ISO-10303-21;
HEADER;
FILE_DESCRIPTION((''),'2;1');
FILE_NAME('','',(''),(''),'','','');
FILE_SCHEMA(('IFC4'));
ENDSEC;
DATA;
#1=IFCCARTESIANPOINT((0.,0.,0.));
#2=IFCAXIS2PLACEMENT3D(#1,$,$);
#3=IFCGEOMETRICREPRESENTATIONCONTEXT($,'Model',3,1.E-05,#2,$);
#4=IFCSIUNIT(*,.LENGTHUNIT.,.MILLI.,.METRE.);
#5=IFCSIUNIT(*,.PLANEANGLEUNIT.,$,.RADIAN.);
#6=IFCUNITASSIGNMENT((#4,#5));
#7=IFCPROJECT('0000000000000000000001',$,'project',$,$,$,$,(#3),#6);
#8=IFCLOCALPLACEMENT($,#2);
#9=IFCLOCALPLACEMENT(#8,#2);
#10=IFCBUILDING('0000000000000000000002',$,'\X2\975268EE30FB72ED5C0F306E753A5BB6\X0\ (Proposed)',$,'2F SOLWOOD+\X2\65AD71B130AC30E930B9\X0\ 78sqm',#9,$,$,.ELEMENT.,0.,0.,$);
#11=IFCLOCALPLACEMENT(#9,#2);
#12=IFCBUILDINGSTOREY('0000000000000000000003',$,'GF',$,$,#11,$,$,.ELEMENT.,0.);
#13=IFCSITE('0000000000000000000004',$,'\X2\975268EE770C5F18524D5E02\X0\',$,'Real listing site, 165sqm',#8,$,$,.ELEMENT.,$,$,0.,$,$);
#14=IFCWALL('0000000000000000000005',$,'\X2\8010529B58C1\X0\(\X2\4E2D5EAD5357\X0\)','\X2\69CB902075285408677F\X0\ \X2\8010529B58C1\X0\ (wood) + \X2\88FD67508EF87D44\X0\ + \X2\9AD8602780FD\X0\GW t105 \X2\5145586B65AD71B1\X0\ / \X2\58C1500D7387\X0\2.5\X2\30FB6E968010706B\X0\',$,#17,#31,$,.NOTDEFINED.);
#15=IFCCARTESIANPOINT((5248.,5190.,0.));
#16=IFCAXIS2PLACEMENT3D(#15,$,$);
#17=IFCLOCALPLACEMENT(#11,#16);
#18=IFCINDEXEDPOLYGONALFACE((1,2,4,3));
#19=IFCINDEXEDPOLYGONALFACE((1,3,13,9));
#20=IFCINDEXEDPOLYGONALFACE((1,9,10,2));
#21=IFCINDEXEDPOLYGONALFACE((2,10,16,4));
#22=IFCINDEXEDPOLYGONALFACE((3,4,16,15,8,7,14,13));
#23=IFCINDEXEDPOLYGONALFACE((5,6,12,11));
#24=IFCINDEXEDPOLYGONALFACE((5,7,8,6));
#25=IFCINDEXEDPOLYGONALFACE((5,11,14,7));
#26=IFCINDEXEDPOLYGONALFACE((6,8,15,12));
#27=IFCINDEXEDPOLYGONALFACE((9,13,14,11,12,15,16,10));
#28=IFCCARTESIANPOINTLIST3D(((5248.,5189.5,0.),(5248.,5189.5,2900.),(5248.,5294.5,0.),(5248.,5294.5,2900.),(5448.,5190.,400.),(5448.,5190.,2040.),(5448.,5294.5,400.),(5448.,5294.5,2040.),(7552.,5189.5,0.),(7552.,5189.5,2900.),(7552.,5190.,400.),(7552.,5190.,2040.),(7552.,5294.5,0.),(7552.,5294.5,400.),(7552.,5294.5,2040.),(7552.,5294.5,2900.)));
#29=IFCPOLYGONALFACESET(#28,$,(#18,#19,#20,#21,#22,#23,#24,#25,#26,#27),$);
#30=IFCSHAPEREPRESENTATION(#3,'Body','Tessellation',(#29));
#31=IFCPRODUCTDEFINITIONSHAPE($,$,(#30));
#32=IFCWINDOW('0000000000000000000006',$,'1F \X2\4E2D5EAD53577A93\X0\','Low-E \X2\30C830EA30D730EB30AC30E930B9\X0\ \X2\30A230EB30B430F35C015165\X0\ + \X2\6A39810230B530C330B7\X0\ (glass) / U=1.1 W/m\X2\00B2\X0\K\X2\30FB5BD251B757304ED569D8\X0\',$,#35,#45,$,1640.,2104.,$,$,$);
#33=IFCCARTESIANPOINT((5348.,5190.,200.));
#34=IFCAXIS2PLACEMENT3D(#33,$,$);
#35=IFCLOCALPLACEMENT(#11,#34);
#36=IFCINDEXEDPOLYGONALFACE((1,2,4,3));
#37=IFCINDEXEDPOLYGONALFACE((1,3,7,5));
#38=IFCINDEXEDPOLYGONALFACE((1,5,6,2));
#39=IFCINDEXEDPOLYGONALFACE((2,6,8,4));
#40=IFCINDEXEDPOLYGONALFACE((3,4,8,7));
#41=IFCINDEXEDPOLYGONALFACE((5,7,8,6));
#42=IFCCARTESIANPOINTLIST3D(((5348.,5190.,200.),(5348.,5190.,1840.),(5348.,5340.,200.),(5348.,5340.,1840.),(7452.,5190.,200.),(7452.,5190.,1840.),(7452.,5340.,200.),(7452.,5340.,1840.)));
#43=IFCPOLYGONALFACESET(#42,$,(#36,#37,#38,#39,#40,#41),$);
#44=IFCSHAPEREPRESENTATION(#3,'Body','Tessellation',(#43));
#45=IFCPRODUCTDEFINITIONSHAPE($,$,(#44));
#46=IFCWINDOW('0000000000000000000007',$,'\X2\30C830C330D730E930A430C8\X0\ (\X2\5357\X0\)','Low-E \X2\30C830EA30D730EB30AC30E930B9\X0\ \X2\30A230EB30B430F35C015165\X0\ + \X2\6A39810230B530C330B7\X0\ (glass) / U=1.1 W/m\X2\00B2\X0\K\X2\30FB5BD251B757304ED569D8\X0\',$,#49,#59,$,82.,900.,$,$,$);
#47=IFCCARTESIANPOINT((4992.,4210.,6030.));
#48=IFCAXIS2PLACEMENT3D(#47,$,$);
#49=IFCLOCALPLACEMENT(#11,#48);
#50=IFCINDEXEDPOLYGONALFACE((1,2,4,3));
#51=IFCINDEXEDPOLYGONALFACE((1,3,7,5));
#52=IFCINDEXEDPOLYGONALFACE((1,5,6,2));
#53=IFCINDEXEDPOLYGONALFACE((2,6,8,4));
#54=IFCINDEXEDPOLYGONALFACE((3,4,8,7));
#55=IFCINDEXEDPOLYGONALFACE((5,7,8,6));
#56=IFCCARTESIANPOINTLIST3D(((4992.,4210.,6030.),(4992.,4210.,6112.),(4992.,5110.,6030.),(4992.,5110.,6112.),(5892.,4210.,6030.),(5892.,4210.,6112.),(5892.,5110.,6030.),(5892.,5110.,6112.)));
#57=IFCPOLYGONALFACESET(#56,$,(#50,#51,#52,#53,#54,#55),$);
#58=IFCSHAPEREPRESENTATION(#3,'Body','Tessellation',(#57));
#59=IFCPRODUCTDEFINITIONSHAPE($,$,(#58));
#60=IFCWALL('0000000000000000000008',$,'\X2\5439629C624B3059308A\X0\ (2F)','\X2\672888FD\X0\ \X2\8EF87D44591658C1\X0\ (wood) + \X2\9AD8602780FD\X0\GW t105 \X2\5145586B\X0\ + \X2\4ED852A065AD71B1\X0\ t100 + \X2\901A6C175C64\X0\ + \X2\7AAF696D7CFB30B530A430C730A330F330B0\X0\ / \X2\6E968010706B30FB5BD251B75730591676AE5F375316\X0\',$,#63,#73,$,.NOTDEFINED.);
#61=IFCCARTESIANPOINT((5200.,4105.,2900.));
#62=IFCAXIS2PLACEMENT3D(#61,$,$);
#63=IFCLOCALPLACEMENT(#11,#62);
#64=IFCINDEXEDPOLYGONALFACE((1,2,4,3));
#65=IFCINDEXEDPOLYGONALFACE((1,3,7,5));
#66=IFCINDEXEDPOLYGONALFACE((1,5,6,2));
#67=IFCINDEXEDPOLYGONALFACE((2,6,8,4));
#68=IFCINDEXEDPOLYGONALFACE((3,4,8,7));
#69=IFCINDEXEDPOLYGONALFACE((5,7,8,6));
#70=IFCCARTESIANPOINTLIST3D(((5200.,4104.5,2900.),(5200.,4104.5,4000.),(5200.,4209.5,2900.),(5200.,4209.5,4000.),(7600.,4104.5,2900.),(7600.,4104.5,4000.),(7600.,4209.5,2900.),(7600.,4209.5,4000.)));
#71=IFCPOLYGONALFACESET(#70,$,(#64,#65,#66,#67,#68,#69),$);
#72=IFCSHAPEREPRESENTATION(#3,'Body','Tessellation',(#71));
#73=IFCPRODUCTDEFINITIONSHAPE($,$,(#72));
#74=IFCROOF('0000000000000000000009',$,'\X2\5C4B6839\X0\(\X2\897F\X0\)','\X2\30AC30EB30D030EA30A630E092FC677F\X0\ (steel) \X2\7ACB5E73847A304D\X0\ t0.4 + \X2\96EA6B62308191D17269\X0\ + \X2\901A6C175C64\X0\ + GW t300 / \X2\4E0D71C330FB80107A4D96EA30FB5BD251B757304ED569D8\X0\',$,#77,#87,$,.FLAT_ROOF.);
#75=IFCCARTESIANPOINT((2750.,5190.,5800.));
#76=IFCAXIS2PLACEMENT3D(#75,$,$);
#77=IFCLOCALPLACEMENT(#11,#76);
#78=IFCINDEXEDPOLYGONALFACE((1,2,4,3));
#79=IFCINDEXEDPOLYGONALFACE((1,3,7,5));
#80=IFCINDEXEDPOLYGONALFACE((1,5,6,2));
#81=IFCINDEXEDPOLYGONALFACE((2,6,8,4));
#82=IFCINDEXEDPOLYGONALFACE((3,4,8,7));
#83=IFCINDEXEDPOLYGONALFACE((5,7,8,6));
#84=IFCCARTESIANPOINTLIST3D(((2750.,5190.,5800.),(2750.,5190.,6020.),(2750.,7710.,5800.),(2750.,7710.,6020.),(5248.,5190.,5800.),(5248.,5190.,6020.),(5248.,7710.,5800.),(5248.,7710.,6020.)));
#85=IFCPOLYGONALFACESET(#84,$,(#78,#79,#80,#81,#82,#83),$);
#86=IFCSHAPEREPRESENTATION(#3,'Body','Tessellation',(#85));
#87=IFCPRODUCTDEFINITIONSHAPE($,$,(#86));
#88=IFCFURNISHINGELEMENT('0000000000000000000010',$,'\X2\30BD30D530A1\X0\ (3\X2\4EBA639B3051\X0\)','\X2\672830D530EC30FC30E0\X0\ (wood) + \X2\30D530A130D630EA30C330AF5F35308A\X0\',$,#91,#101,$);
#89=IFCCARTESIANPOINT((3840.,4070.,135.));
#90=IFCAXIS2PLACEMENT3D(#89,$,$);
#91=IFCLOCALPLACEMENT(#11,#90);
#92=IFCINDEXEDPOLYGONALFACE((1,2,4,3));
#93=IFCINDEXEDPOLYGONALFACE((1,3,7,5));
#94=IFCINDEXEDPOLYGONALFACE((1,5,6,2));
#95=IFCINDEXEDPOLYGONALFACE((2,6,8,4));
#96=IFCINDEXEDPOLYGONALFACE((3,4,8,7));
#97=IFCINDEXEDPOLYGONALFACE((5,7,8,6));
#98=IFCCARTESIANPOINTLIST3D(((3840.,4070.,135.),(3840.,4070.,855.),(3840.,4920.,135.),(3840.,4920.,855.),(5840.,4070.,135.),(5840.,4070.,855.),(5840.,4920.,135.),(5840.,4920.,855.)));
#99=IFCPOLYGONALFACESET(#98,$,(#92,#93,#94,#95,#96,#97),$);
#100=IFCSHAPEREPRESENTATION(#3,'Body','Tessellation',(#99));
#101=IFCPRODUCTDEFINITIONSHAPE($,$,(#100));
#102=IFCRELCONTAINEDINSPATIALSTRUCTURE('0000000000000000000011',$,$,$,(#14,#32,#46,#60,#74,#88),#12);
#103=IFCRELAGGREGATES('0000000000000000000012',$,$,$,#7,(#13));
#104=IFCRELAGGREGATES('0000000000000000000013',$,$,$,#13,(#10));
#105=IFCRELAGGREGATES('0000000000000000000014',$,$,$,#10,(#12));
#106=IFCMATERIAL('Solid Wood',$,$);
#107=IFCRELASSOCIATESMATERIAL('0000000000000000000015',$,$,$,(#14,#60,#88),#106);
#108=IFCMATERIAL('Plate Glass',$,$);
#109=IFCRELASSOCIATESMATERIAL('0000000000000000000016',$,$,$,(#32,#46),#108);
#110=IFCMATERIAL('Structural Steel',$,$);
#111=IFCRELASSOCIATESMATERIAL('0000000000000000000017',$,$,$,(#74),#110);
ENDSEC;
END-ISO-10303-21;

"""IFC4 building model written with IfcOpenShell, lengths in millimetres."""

from ifc_helpers import new_model, si_unit, frame, frame_2d, origin, place, context, project, spatial, rectangle, extrude, material, element, fill, save


model = new_model("IFC4")

# Units and contexts
model_context = context("Model", 3, precision=1e-05, world=origin())
ifc_project = project(units=[si_unit("LENGTHUNIT", "METRE", prefix="MILLI"), si_unit("PLANEANGLEUNIT", "RADIAN")], contexts=[model_context])

# Site, building, storey
site_placement = place(None, origin())
site = spatial("IfcSite", under=ifc_project, at=site_placement, Name="青森県弘前市", ObjectType="Real listing site, 165sqm", CompositionType="ELEMENT", RefElevation=0.0)
building_placement = place(site_placement, origin())
building = spatial("IfcBuilding", under=site, at=building_placement, Name="青森・狭小の町家 (Proposed)", ObjectType="2F SOLWOOD+断熱ガラス 78sqm", CompositionType="ELEMENT", ElevationOfRefHeight=0.0, ElevationOfTerrain=0.0)
storey_placement = place(building_placement, origin())
storey = spatial("IfcBuildingStorey", under=building, at=storey_placement, Name="GF", CompositionType="ELEMENT", Elevation=0.0)

# Shared definitions
ifc_material_1 = material(Name="Solid Wood")

# Wall, opening, window
wall_1_placement = place(storey_placement, frame((5248.0, 5190.0, 0.0)))
wall_1 = element("IfcWall", 1, at=wall_1_placement, inside=storey, material=ifc_material_1, Name="耐力壁(中庭南)", Description="構造用合板 耐力壁 (wood) + 製材軸組 + 高性能GW t105 充填断熱 / 壁倍率2.5・準耐火", PredefinedType="NOTDEFINED", context=model_context, shape_type="SweptSolid", body=[
    extrude(rectangle(XDim=2304.0, YDim=105.0, at=frame_2d((1152.0, 52.0))), frame((5248.0, 5190.0, 0.0)), (0.0, 0.0, 1.0), 2900.0),
])
opening_placement = place(storey_placement, frame((5348.0, 5190.0, 200.0)))
opening = element("IfcOpeningElement", 2, at=opening_placement, cuts=wall_1, PredefinedType="NOTDEFINED", context=model_context, shape_type="SweptSolid", body=[
    extrude(rectangle(XDim=2104.0, YDim=150.0, at=frame_2d((1052.0, 75.0))), frame((5348.0, 5190.0, 200.0)), (0.0, 0.0, 1.0), 1640.0),
])
ifc_material_2 = material(Name="Plate Glass")
window_1_placement = place(storey_placement, frame((5348.0, 5190.0, 200.0)))
window_1 = element("IfcWindow", 3, at=window_1_placement, inside=storey, material=ifc_material_2, Name="1F 中庭南窓", Description="Low-E トリプルガラス アルゴン封入 + 樹脂サッシ (glass) / U=1.1 W/m²K・寒冷地仕様", OverallHeight=1640.0, OverallWidth=2104.0, context=model_context, shape_type="SweptSolid", body=[
    extrude(rectangle(XDim=2104.0, YDim=150.0, at=frame_2d((1052.0, 75.0))), frame((5348.0, 5190.0, 200.0)), (0.0, 0.0, 1.0), 1640.0),
])
fill(opening, window_1)

# Window
window_2_placement = place(storey_placement, frame((4992.0, 4210.0, 6030.0)))
element("IfcWindow", 4, at=window_2_placement, inside=storey, material=ifc_material_2, Name="トップライト (南)", Description="Low-E トリプルガラス アルゴン封入 + 樹脂サッシ (glass) / U=1.1 W/m²K・寒冷地仕様", OverallHeight=82.0, OverallWidth=900.0, context=model_context, shape_type="SweptSolid", body=[
    extrude(rectangle(XDim=900.0, YDim=900.0, at=frame_2d((450.0, 450.0))), frame((4992.0, 4210.0, 6030.0)), (0.0, 0.0, 1.0), 82.0),
])

# Wall
wall_2_placement = place(storey_placement, frame((5200.0, 4105.0, 2900.0)))
element("IfcWall", 5, at=wall_2_placement, inside=storey, material=ifc_material_1, Name="吹抜手すり (2F)", Description="木製 軸組外壁 (wood) + 高性能GW t105 充填 + 付加断熱 t100 + 通気層 + 窯業系サイディング / 準耐火・寒冷地外皮強化", PredefinedType="NOTDEFINED", context=model_context, shape_type="SweptSolid", body=[
    extrude(rectangle(XDim=2400.0, YDim=105.0, at=frame_2d((1200.0, 52.0))), frame((5200.0, 4105.0, 2900.0)), (0.0, 0.0, 1.0), 1100.0),
])

# Roof
ifc_material_3 = material(Name="Structural Steel")
for number, where, name in (
    (6, (2750.0, 5190.0, 5800.0), "屋根(西)"),
):
    element("IfcRoof", number, at=place(storey_placement, frame(where)), inside=storey, material=ifc_material_3, Name=name, Description="ガルバリウム鋼板 (steel) 立平葺き t0.4 + 雪止め金物 + 通気層 + GW t300 / 不燃・耐積雪・寒冷地仕様", PredefinedType="FLAT_ROOF", context=model_context, shape_type="SweptSolid", body=[
        extrude(rectangle(XDim=2498.0, YDim=2520.0, at=frame_2d((1249.0, 1260.0))), frame((2750.0, 5190.0, 5800.0)), (0.0, 0.0, 1.0), 220.0),
    ])

# Furnishing element
furnishing_placement = place(storey_placement, frame((3840.0, 4070.0, 135.0)))
element("IfcFurnishingElement", 7, at=furnishing_placement, inside=storey, material=ifc_material_1, Name="ソファ (3人掛け)", Description="木フレーム (wood) + ファブリック張り", context=model_context, shape_type="SweptSolid", body=[
    extrude(rectangle(XDim=2000.0, YDim=850.0, at=frame_2d((1000.0, 425.0))), frame((3840.0, 4070.0, 135.0)), (0.0, 0.0, 1.0), 720.0),
])

save(model, "model.ifc")
